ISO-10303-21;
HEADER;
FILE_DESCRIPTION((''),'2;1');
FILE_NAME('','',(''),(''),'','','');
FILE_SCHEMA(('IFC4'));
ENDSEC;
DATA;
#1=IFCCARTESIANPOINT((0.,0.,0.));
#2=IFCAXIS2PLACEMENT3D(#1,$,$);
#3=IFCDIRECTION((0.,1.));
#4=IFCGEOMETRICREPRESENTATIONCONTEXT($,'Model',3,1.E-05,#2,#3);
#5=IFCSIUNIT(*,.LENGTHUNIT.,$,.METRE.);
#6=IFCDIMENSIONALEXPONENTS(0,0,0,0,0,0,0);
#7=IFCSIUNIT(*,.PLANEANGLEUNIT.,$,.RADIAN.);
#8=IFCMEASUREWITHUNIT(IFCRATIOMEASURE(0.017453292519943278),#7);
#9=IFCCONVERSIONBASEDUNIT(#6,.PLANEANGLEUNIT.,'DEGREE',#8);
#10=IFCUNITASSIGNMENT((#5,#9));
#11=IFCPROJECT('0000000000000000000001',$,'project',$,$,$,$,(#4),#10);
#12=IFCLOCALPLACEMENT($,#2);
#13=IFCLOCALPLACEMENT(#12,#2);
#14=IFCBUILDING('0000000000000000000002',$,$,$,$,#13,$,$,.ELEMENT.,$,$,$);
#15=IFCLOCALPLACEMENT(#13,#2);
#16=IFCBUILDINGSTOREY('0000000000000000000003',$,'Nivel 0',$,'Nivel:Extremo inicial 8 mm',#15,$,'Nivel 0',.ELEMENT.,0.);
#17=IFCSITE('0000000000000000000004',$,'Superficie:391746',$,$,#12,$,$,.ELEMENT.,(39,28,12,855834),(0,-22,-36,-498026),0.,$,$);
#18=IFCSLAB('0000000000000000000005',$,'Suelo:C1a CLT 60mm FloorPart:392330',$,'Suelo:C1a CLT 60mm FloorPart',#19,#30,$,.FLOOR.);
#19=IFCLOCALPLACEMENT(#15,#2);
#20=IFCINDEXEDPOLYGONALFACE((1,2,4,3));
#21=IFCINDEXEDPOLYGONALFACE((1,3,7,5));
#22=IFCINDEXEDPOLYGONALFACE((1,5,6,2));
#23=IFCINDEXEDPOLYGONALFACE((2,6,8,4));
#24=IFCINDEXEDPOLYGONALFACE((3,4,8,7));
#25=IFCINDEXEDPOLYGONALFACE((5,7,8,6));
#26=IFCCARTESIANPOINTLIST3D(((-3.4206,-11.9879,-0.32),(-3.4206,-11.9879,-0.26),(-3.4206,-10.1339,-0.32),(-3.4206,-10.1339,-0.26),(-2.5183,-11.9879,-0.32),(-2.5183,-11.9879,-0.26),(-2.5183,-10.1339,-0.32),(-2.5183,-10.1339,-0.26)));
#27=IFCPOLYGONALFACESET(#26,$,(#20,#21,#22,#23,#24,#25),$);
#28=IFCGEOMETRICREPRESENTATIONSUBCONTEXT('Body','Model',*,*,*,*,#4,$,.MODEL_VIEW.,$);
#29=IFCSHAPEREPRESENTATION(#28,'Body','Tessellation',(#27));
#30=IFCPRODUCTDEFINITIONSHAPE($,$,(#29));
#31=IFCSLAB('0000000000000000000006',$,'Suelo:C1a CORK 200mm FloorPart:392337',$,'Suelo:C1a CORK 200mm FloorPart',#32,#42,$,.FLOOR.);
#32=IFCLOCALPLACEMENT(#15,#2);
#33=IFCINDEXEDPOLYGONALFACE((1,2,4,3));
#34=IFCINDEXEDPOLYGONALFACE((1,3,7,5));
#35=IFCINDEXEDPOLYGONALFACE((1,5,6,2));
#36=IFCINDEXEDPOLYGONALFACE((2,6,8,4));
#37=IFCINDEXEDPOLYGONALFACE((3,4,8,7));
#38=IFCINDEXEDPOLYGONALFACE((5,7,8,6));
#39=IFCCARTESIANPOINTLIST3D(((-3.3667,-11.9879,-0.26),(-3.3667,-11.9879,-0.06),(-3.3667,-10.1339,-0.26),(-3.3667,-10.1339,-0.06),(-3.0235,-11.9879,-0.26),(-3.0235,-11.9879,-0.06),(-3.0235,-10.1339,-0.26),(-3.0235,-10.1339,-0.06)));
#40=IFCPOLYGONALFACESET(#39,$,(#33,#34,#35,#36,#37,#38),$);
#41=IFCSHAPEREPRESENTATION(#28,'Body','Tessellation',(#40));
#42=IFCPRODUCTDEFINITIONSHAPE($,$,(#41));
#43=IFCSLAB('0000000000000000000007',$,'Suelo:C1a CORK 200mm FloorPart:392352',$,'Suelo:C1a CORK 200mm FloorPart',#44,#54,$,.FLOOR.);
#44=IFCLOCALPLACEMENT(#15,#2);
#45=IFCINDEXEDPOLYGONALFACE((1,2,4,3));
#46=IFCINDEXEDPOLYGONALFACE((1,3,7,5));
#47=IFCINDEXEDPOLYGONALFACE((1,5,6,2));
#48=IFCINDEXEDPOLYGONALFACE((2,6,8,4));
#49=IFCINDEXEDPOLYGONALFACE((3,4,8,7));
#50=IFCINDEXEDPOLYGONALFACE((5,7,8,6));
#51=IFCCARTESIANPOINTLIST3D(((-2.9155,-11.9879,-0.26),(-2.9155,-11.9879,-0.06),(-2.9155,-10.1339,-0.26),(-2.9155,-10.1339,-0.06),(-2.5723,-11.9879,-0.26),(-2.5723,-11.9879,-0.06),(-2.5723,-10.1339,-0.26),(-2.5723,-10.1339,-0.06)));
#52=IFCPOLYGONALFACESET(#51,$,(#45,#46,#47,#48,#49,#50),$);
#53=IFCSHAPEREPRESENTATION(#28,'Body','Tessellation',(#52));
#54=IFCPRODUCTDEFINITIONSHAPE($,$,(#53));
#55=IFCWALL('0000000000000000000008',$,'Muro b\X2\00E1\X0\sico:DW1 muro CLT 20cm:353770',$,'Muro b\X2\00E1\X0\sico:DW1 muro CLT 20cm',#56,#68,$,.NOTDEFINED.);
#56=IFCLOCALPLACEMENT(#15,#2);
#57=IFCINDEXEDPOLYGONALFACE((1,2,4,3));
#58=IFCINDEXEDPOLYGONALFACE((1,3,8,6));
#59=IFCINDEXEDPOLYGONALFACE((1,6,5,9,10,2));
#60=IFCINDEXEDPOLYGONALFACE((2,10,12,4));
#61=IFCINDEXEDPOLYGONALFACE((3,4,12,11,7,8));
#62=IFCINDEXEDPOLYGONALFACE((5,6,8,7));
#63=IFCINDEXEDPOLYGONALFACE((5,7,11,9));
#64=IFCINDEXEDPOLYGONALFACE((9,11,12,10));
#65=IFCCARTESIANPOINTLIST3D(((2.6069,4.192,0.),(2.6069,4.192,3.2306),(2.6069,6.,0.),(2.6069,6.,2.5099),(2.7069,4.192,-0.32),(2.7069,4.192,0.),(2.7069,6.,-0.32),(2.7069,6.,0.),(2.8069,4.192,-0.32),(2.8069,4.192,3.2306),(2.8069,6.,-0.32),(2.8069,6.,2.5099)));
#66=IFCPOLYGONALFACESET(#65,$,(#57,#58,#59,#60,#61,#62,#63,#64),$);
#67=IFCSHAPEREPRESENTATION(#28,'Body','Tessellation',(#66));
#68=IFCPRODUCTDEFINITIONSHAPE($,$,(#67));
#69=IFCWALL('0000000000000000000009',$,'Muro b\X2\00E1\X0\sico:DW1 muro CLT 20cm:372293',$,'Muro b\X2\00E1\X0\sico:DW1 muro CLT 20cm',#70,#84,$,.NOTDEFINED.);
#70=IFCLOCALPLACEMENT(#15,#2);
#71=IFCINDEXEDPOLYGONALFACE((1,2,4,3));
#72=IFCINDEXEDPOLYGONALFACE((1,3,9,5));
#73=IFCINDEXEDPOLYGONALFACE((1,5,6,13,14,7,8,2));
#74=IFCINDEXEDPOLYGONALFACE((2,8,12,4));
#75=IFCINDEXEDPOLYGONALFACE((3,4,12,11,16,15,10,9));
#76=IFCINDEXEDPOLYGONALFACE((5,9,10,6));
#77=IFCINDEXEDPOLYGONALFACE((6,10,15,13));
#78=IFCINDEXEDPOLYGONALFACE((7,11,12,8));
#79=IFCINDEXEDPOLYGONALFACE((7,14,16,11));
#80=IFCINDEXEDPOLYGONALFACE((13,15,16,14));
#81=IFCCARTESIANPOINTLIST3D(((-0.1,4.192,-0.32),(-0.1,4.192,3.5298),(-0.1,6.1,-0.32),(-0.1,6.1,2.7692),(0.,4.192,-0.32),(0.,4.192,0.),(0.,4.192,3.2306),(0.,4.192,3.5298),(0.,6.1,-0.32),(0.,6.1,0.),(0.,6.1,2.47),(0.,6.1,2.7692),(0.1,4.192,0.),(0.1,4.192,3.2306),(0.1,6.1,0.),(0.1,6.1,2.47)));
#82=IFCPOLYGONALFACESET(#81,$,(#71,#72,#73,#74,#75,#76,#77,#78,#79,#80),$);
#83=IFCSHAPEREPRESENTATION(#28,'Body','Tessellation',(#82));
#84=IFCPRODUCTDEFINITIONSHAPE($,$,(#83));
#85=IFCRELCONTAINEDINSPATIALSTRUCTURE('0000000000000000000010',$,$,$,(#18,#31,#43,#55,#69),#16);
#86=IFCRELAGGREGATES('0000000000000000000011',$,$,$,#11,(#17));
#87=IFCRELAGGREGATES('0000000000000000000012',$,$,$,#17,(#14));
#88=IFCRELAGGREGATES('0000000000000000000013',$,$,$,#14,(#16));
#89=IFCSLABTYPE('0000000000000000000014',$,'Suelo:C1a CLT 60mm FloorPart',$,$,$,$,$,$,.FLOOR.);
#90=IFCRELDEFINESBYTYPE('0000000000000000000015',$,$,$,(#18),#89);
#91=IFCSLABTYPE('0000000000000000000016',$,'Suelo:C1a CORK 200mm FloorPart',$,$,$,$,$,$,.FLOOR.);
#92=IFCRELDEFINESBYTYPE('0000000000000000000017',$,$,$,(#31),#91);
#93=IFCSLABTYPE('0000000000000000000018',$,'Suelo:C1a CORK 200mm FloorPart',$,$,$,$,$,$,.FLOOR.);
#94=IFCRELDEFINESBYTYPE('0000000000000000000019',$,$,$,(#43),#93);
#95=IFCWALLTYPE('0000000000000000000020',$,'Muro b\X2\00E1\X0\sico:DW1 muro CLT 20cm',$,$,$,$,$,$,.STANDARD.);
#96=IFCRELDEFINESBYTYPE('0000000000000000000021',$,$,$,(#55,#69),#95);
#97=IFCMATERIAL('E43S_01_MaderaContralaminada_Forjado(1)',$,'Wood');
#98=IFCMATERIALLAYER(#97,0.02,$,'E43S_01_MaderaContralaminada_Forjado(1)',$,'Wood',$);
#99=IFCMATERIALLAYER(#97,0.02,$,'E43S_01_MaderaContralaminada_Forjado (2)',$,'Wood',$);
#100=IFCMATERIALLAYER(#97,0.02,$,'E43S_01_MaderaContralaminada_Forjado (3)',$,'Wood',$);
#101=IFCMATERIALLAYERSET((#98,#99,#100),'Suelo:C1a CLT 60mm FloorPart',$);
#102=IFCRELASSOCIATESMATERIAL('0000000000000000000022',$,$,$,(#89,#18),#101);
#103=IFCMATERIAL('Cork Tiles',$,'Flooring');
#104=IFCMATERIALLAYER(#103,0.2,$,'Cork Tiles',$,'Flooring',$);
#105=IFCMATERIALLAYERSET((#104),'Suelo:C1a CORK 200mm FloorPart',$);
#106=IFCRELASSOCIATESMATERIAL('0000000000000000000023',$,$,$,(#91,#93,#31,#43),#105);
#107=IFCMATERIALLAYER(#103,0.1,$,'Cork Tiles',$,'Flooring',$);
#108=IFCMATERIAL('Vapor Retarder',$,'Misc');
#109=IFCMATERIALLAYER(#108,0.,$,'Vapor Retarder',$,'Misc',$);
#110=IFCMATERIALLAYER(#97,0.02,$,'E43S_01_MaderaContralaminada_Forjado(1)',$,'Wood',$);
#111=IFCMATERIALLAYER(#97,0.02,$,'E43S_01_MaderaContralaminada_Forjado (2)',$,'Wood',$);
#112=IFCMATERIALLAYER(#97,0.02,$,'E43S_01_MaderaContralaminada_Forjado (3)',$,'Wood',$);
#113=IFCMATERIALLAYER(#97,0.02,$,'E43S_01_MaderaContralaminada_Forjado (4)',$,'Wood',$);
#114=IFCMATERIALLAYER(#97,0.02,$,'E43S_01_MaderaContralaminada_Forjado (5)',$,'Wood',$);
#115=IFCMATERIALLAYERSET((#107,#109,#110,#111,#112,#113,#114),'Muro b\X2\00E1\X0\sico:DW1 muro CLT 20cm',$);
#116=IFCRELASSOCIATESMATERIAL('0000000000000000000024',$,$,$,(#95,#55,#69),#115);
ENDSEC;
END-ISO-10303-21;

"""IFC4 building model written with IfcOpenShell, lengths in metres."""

from ifc_helpers import new_model, entity, si_unit, converted_unit, direction, frame, frame_2d, origin, place, context, subcontext, project, spatial, polyline, rectangle, extrude, clip, bounded_halfspace, material, layer, layer_set, layer_usage, type_object, element, save


model = new_model("IFC4")

# Units and contexts
model_context = context("Model", 3, precision=1e-05, world=origin(), true_north=direction((0.0, 1.0)))
body_context = subcontext(model_context, "Body", "Model", "MODEL_VIEW")
ifc_project = project(units=[si_unit("LENGTHUNIT", "METRE"), converted_unit("PLANEANGLEUNIT", "DEGREE", entity("IfcRatioMeasure", 0.017453292519943278), si_unit("PLANEANGLEUNIT", "RADIAN"), dimensions=[0, 0, 0, 0, 0, 0, 0])], contexts=[model_context])

# Site, building, storey
site_placement = place(None, origin())
site = spatial("IfcSite", under=ifc_project, at=site_placement, Name="Superficie:391746", CompositionType="ELEMENT", RefLatitude=(39, 28, 12, 855834), RefLongitude=(0, -22, -36, -498026), RefElevation=0.0)
building_placement = place(site_placement, origin())
building = spatial("IfcBuilding", under=site, at=building_placement, CompositionType="ELEMENT")
storey_placement = place(building_placement, origin())
storey = spatial("IfcBuildingStorey", under=building, at=storey_placement, Name="Nivel 0", ObjectType="Nivel:Extremo inicial 8 mm", LongName="Nivel 0", CompositionType="ELEMENT", Elevation=0.0)

# Shared definitions
ifc_material_1 = material(Name="E43S_01_MaderaContralaminada_Forjado(1)", Category="Wood")

# Slabs
ifc_layer_1 = layer(ifc_material_1, 0.02, Name="E43S_01_MaderaContralaminada_Forjado(1)", Category="Wood")
ifc_layer_2 = layer(ifc_material_1, 0.02, Name="E43S_01_MaderaContralaminada_Forjado (2)", Category="Wood")
ifc_layer_3 = layer(ifc_material_1, 0.02, Name="E43S_01_MaderaContralaminada_Forjado (3)", Category="Wood")
ifc_layer_set_1 = layer_set([ifc_layer_1, ifc_layer_2, ifc_layer_3], Name="Suelo:C1a CLT 60mm FloorPart")
ifc_material_2 = material(Name="Cork Tiles", Category="Flooring")
ifc_layer_4 = layer(ifc_material_2, 0.2, Name="Cork Tiles", Category="Flooring")
ifc_layer_set_2 = layer_set([ifc_layer_4], Name="Suelo:C1a CORK 200mm FloorPart")
ifc_layer_usage_1 = layer_usage(ifc_layer_set_1, "AXIS3", "POSITIVE", 0.0)
slab_type_1 = type_object("IfcSlabType", Name="Suelo:C1a CLT 60mm FloorPart", PredefinedType="FLOOR", material=ifc_layer_set_1)
slab_1_placement = place(storey_placement, origin())
element("IfcSlab", 1, at=slab_1_placement, inside=storey, type_object=slab_type_1, material=ifc_layer_usage_1, Name="Suelo:C1a CLT 60mm FloorPart:392330", ObjectType="Suelo:C1a CLT 60mm FloorPart", PredefinedType="FLOOR", context=body_context, shape_type="SweptSolid", body=[
    extrude(rectangle(XDim=1.854, YDim=0.9023, at=frame_2d((0.0, 0.0), x_axis=(1.0, 0.0))), frame((-2.9695, -11.0609, -0.26), z_axis=(0.0, 0.0, -1.0), x_axis=(0.0, 1.0, 0.0)), (0.0, 0.0, 1.0), 0.06),
])
ifc_layer_usage_2 = layer_usage(ifc_layer_set_2, "AXIS3", "POSITIVE", 0.0)
slab_type_2 = type_object("IfcSlabType", Name="Suelo:C1a CORK 200mm FloorPart", PredefinedType="FLOOR", material=ifc_layer_set_2)
slab_2_placement = place(storey_placement, origin())
element("IfcSlab", 2, at=slab_2_placement, inside=storey, type_object=slab_type_2, material=ifc_layer_usage_2, Name="Suelo:C1a CORK 200mm FloorPart:392337", ObjectType="Suelo:C1a CORK 200mm FloorPart", PredefinedType="FLOOR", context=body_context, shape_type="SweptSolid", body=[
    extrude(rectangle(XDim=1.854, YDim=0.3432, at=frame_2d((0.0, 0.0), x_axis=(1.0, 0.0))), frame((-3.1951, -11.0609, -0.06), z_axis=(0.0, 0.0, -1.0), x_axis=(0.0, 1.0, 0.0)), (0.0, 0.0, 1.0), 0.2),
])
ifc_layer_usage_3 = layer_usage(ifc_layer_set_2, "AXIS3", "POSITIVE", 0.0)
slab_type_3 = type_object("IfcSlabType", Name="Suelo:C1a CORK 200mm FloorPart", PredefinedType="FLOOR", material=ifc_layer_set_2)
slab_3_placement = place(storey_placement, origin())
element("IfcSlab", 3, at=slab_3_placement, inside=storey, type_object=slab_type_3, material=ifc_layer_usage_3, Name="Suelo:C1a CORK 200mm FloorPart:392352", ObjectType="Suelo:C1a CORK 200mm FloorPart", PredefinedType="FLOOR", context=body_context, shape_type="SweptSolid", body=[
    extrude(rectangle(XDim=1.854, YDim=0.3432, at=frame_2d((0.0, 0.0), x_axis=(1.0, 0.0))), frame((-2.7439, -11.0609, -0.06), z_axis=(0.0, 0.0, -1.0), x_axis=(0.0, 1.0, 0.0)), (0.0, 0.0, 1.0), 0.2),
])

# Walls
ifc_layer_5 = layer(ifc_material_2, 0.1, Name="Cork Tiles", Category="Flooring")
ifc_material_3 = material(Name="Vapor Retarder", Category="Misc")
ifc_layer_6 = layer(ifc_material_3, 0.0, Name="Vapor Retarder", Category="Misc")
ifc_layer_7 = layer(ifc_material_1, 0.02, Name="E43S_01_MaderaContralaminada_Forjado(1)", Category="Wood")
ifc_layer_8 = layer(ifc_material_1, 0.02, Name="E43S_01_MaderaContralaminada_Forjado (2)", Category="Wood")
ifc_layer_9 = layer(ifc_material_1, 0.02, Name="E43S_01_MaderaContralaminada_Forjado (3)", Category="Wood")
ifc_layer_10 = layer(ifc_material_1, 0.02, Name="E43S_01_MaderaContralaminada_Forjado (4)", Category="Wood")
ifc_layer_11 = layer(ifc_material_1, 0.02, Name="E43S_01_MaderaContralaminada_Forjado (5)", Category="Wood")
ifc_layer_set_3 = layer_set([ifc_layer_5, ifc_layer_6, ifc_layer_7, ifc_layer_8, ifc_layer_9, ifc_layer_10, ifc_layer_11], Name="Muro básico:DW1 muro CLT 20cm")
ifc_layer_usage_4 = layer_usage(ifc_layer_set_3, "AXIS2", "NEGATIVE", 0.1)
wall_type_1 = type_object("IfcWallType", Name="Muro básico:DW1 muro CLT 20cm", PredefinedType="STANDARD", material=ifc_layer_set_3)
wall_1_placement = place(storey_placement, frame((2.7069, 6.0, -0.32), z_axis=(0.0, 0.0, 1.0), x_axis=(0.0, -1.0, 0.0)))
element("IfcWall", 4, at=wall_1_placement, inside=storey, type_object=wall_type_1, material=ifc_layer_usage_4, Name="Muro básico:DW1 muro CLT 20cm:353770", ObjectType="Muro básico:DW1 muro CLT 20cm", PredefinedType="NOTDEFINED", context=body_context, shape_type="Clipping", body=[
    clip(clip(extrude(rectangle(XDim=1.808, YDim=0.2, at=frame_2d((0.904, 0.0), x_axis=(-1.0, 0.0))), origin(), (0.0, 0.0, 1.0), 3.5506), bounded_halfspace(frame((0.0, -0.1, 2.8299), z_axis=(-0.370288, 0.0, 0.928917), x_axis=(0.0, -1.0, 0.0)), False, frame((0.0, -0.1, 2.8299)), polyline([(0.0, 0.0), (1.808, 0.0), (1.808, 0.2), (0.0, 0.2), (0.0, 0.0)]))), bounded_halfspace(frame((1.808, -0.1, 0.32), z_axis=(0.0, 0.0, -1.0), x_axis=(0.0, 1.0, 0.0)), False, frame((1.808, -0.1, 0.32)), polyline([(0.0, 0.0), (0.0, 0.1), (-0.1, 0.1), (-1.808, 0.1), (-1.808, 0.0), (-0.2, 0.0), (0.0, 0.0)]))),
])
ifc_layer_usage_5 = layer_usage(ifc_layer_set_3, "AXIS2", "NEGATIVE", 0.1)
wall_2_placement = place(storey_placement, frame((0.0, 4.192, -0.32), z_axis=(0.0, 0.0, 1.0), x_axis=(0.0, 1.0, 0.0)))
element("IfcWall", 5, at=wall_2_placement, inside=storey, type_object=wall_type_1, material=ifc_layer_usage_5, Name="Muro básico:DW1 muro CLT 20cm:372293", ObjectType="Muro básico:DW1 muro CLT 20cm", PredefinedType="NOTDEFINED", context=body_context, shape_type="Clipping", body=[
    clip(clip(clip(extrude(rectangle(XDim=1.908, YDim=0.2, at=frame_2d((0.954, 0.0), x_axis=(-1.0, 0.0))), origin(), (0.0, 0.0, 1.0), 3.8498), bounded_halfspace(frame((0.0, -0.1, 3.5506), z_axis=(0.370288, 0.0, 0.928917), x_axis=(0.0, 1.0, 0.0)), False, frame((0.0, -0.1, 3.5506)), polyline([(0.0, 0.0), (1.708, 0.0), (1.908, 0.0), (1.908, 0.1), (0.0, 0.1), (0.0, 0.0)]))), bounded_halfspace(frame((1.908, 0.0, 3.0892), z_axis=(0.370288, 0.0, 0.928917), x_axis=(0.0, 1.0, 0.0)), False, frame((1.908, 0.0, 3.0892)), polyline([(0.0, 0.0), (0.0, 0.1), (-1.908, 0.1), (-1.908, 0.0), (0.0, 0.0)]))), bounded_halfspace(frame((1.908, -0.1, 0.32), z_axis=(0.0, 0.0, -1.0), x_axis=(0.0, 1.0, 0.0)), False, frame((1.908, -0.1, 0.32)), polyline([(0.0, 0.0), (0.0, 0.1), (-1.808, 0.1), (-1.908, 0.1), (-1.908, 0.0), (-1.708, 0.0), (-0.2, 0.0), (-0.1, 0.0), (0.0, 0.0)]))),
])

save(model, "model.ifc")
